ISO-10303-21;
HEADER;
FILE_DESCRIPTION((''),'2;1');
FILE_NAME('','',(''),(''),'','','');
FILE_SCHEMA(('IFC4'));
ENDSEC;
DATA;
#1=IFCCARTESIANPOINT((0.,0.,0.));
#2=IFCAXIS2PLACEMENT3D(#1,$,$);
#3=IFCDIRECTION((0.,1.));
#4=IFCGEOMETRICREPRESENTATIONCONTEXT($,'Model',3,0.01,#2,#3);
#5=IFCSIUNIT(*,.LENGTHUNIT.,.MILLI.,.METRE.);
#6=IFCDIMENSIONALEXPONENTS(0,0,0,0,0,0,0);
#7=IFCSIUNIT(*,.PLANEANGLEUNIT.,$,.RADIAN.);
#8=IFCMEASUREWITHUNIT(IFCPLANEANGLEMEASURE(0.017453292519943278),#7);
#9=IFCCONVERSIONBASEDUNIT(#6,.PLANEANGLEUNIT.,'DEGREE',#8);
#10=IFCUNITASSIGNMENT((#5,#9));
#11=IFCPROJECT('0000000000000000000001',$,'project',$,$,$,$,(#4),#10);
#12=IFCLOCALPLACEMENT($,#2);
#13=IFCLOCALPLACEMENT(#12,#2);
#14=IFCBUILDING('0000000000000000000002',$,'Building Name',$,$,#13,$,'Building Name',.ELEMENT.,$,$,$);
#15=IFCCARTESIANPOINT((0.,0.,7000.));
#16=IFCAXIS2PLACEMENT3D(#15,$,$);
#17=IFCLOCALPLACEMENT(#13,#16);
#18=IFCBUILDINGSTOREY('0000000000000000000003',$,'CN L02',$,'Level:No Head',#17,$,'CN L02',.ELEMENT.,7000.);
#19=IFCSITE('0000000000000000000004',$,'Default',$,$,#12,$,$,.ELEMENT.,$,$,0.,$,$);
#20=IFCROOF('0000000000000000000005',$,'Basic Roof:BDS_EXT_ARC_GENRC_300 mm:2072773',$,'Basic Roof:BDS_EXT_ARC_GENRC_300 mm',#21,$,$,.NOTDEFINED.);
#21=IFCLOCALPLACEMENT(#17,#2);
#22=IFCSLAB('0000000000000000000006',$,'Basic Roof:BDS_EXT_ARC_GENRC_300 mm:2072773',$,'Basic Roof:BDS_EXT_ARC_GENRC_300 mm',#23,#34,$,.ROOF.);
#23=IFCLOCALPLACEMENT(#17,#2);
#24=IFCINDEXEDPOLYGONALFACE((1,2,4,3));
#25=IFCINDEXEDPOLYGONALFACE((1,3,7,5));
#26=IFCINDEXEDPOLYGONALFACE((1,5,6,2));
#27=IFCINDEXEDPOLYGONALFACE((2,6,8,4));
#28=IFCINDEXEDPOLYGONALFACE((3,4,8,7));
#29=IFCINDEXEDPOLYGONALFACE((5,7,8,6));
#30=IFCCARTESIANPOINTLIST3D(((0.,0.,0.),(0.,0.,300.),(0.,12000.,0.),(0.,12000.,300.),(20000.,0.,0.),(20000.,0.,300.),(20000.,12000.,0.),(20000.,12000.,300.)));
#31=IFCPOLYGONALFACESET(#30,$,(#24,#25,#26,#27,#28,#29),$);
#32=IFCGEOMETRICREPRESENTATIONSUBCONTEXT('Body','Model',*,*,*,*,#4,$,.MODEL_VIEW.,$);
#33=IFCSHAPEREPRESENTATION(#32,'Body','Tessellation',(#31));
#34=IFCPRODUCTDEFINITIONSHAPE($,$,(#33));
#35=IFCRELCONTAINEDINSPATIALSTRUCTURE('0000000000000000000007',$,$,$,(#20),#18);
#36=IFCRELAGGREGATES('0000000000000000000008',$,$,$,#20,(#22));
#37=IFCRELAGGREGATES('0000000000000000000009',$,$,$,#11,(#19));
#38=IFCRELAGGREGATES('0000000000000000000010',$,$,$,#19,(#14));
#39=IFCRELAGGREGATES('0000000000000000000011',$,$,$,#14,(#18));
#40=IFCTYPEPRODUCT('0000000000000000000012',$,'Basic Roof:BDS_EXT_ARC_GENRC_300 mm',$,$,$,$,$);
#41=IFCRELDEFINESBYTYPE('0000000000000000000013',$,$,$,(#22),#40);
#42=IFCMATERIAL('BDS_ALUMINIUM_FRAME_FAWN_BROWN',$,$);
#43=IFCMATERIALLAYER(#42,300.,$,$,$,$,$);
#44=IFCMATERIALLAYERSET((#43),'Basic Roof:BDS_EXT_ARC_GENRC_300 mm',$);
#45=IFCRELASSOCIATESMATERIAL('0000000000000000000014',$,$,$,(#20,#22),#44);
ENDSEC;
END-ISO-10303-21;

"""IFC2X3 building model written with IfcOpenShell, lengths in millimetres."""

from ifc_helpers import new_model, entity, si_unit, converted_unit, direction, frame, frame_2d, origin, place, context, subcontext, project, spatial, rectangle, extrude, material, layer, layer_set, type_object, element, aggregate, save


model = new_model("IFC2X3")

# Units and contexts
model_context = context("Model", 3, precision=0.01, world=origin(), true_north=direction((0.0, 1.0)))
body_context = subcontext(model_context, "Body", "Model", "MODEL_VIEW")
ifc_project = project(units=[si_unit("LENGTHUNIT", "METRE", prefix="MILLI"), converted_unit("PLANEANGLEUNIT", "DEGREE", entity("IfcPlaneAngleMeasure", 0.017453292519943278), si_unit("PLANEANGLEUNIT", "RADIAN"), dimensions=[0, 0, 0, 0, 0, 0, 0])], contexts=[model_context])

# Site, building, storey
site_placement = place(None, origin())
site = spatial("IfcSite", under=ifc_project, at=site_placement, Name="Default", CompositionType="ELEMENT", RefElevation=0.0)
building_placement = place(site_placement, origin())
building = spatial("IfcBuilding", under=site, at=building_placement, Name="Building Name", LongName="Building Name", CompositionType="ELEMENT")
storey_placement = place(building_placement, frame((0.0, 0.0, 7000.0)))
storey = spatial("IfcBuildingStorey", under=building, at=storey_placement, Name="CN L02", ObjectType="Level:No Head", LongName="CN L02", CompositionType="ELEMENT", Elevation=7000.0)

# Roof, slab
ifc_material = material(Name="BDS_ALUMINIUM_FRAME_FAWN_BROWN")
ifc_layer = layer(ifc_material, 300.0)
ifc_layer_set = layer_set([ifc_layer], Name="Basic Roof:BDS_EXT_ARC_GENRC_300 mm")
roof_placement = place(storey_placement, origin())
roof = element("IfcRoof", 1, at=roof_placement, inside=storey, material=ifc_layer_set, Name="Basic Roof:BDS_EXT_ARC_GENRC_300 mm:2072773", ObjectType="Basic Roof:BDS_EXT_ARC_GENRC_300 mm", ShapeType="NOTDEFINED")
type_product = type_object("IfcTypeProduct", Name="Basic Roof:BDS_EXT_ARC_GENRC_300 mm")
slab_placement = place(roof_placement, origin())
slab = element("IfcSlab", 2, at=slab_placement, type_object=type_product, material=ifc_layer_set, Name="Basic Roof:BDS_EXT_ARC_GENRC_300 mm:2072773", ObjectType="Basic Roof:BDS_EXT_ARC_GENRC_300 mm", PredefinedType="ROOF", context=body_context, shape_type="SweptSolid", body=[
    extrude(rectangle(XDim=20000.0, YDim=12000.0, at=frame_2d((0.0, 0.0), x_axis=(-1.0, 0.0))), frame((10000.0, 6000.0, 0.0)), (0.0, 0.0, 1.0), 300.0),
])
aggregate(roof, [slab])

save(model, "model.ifc")
